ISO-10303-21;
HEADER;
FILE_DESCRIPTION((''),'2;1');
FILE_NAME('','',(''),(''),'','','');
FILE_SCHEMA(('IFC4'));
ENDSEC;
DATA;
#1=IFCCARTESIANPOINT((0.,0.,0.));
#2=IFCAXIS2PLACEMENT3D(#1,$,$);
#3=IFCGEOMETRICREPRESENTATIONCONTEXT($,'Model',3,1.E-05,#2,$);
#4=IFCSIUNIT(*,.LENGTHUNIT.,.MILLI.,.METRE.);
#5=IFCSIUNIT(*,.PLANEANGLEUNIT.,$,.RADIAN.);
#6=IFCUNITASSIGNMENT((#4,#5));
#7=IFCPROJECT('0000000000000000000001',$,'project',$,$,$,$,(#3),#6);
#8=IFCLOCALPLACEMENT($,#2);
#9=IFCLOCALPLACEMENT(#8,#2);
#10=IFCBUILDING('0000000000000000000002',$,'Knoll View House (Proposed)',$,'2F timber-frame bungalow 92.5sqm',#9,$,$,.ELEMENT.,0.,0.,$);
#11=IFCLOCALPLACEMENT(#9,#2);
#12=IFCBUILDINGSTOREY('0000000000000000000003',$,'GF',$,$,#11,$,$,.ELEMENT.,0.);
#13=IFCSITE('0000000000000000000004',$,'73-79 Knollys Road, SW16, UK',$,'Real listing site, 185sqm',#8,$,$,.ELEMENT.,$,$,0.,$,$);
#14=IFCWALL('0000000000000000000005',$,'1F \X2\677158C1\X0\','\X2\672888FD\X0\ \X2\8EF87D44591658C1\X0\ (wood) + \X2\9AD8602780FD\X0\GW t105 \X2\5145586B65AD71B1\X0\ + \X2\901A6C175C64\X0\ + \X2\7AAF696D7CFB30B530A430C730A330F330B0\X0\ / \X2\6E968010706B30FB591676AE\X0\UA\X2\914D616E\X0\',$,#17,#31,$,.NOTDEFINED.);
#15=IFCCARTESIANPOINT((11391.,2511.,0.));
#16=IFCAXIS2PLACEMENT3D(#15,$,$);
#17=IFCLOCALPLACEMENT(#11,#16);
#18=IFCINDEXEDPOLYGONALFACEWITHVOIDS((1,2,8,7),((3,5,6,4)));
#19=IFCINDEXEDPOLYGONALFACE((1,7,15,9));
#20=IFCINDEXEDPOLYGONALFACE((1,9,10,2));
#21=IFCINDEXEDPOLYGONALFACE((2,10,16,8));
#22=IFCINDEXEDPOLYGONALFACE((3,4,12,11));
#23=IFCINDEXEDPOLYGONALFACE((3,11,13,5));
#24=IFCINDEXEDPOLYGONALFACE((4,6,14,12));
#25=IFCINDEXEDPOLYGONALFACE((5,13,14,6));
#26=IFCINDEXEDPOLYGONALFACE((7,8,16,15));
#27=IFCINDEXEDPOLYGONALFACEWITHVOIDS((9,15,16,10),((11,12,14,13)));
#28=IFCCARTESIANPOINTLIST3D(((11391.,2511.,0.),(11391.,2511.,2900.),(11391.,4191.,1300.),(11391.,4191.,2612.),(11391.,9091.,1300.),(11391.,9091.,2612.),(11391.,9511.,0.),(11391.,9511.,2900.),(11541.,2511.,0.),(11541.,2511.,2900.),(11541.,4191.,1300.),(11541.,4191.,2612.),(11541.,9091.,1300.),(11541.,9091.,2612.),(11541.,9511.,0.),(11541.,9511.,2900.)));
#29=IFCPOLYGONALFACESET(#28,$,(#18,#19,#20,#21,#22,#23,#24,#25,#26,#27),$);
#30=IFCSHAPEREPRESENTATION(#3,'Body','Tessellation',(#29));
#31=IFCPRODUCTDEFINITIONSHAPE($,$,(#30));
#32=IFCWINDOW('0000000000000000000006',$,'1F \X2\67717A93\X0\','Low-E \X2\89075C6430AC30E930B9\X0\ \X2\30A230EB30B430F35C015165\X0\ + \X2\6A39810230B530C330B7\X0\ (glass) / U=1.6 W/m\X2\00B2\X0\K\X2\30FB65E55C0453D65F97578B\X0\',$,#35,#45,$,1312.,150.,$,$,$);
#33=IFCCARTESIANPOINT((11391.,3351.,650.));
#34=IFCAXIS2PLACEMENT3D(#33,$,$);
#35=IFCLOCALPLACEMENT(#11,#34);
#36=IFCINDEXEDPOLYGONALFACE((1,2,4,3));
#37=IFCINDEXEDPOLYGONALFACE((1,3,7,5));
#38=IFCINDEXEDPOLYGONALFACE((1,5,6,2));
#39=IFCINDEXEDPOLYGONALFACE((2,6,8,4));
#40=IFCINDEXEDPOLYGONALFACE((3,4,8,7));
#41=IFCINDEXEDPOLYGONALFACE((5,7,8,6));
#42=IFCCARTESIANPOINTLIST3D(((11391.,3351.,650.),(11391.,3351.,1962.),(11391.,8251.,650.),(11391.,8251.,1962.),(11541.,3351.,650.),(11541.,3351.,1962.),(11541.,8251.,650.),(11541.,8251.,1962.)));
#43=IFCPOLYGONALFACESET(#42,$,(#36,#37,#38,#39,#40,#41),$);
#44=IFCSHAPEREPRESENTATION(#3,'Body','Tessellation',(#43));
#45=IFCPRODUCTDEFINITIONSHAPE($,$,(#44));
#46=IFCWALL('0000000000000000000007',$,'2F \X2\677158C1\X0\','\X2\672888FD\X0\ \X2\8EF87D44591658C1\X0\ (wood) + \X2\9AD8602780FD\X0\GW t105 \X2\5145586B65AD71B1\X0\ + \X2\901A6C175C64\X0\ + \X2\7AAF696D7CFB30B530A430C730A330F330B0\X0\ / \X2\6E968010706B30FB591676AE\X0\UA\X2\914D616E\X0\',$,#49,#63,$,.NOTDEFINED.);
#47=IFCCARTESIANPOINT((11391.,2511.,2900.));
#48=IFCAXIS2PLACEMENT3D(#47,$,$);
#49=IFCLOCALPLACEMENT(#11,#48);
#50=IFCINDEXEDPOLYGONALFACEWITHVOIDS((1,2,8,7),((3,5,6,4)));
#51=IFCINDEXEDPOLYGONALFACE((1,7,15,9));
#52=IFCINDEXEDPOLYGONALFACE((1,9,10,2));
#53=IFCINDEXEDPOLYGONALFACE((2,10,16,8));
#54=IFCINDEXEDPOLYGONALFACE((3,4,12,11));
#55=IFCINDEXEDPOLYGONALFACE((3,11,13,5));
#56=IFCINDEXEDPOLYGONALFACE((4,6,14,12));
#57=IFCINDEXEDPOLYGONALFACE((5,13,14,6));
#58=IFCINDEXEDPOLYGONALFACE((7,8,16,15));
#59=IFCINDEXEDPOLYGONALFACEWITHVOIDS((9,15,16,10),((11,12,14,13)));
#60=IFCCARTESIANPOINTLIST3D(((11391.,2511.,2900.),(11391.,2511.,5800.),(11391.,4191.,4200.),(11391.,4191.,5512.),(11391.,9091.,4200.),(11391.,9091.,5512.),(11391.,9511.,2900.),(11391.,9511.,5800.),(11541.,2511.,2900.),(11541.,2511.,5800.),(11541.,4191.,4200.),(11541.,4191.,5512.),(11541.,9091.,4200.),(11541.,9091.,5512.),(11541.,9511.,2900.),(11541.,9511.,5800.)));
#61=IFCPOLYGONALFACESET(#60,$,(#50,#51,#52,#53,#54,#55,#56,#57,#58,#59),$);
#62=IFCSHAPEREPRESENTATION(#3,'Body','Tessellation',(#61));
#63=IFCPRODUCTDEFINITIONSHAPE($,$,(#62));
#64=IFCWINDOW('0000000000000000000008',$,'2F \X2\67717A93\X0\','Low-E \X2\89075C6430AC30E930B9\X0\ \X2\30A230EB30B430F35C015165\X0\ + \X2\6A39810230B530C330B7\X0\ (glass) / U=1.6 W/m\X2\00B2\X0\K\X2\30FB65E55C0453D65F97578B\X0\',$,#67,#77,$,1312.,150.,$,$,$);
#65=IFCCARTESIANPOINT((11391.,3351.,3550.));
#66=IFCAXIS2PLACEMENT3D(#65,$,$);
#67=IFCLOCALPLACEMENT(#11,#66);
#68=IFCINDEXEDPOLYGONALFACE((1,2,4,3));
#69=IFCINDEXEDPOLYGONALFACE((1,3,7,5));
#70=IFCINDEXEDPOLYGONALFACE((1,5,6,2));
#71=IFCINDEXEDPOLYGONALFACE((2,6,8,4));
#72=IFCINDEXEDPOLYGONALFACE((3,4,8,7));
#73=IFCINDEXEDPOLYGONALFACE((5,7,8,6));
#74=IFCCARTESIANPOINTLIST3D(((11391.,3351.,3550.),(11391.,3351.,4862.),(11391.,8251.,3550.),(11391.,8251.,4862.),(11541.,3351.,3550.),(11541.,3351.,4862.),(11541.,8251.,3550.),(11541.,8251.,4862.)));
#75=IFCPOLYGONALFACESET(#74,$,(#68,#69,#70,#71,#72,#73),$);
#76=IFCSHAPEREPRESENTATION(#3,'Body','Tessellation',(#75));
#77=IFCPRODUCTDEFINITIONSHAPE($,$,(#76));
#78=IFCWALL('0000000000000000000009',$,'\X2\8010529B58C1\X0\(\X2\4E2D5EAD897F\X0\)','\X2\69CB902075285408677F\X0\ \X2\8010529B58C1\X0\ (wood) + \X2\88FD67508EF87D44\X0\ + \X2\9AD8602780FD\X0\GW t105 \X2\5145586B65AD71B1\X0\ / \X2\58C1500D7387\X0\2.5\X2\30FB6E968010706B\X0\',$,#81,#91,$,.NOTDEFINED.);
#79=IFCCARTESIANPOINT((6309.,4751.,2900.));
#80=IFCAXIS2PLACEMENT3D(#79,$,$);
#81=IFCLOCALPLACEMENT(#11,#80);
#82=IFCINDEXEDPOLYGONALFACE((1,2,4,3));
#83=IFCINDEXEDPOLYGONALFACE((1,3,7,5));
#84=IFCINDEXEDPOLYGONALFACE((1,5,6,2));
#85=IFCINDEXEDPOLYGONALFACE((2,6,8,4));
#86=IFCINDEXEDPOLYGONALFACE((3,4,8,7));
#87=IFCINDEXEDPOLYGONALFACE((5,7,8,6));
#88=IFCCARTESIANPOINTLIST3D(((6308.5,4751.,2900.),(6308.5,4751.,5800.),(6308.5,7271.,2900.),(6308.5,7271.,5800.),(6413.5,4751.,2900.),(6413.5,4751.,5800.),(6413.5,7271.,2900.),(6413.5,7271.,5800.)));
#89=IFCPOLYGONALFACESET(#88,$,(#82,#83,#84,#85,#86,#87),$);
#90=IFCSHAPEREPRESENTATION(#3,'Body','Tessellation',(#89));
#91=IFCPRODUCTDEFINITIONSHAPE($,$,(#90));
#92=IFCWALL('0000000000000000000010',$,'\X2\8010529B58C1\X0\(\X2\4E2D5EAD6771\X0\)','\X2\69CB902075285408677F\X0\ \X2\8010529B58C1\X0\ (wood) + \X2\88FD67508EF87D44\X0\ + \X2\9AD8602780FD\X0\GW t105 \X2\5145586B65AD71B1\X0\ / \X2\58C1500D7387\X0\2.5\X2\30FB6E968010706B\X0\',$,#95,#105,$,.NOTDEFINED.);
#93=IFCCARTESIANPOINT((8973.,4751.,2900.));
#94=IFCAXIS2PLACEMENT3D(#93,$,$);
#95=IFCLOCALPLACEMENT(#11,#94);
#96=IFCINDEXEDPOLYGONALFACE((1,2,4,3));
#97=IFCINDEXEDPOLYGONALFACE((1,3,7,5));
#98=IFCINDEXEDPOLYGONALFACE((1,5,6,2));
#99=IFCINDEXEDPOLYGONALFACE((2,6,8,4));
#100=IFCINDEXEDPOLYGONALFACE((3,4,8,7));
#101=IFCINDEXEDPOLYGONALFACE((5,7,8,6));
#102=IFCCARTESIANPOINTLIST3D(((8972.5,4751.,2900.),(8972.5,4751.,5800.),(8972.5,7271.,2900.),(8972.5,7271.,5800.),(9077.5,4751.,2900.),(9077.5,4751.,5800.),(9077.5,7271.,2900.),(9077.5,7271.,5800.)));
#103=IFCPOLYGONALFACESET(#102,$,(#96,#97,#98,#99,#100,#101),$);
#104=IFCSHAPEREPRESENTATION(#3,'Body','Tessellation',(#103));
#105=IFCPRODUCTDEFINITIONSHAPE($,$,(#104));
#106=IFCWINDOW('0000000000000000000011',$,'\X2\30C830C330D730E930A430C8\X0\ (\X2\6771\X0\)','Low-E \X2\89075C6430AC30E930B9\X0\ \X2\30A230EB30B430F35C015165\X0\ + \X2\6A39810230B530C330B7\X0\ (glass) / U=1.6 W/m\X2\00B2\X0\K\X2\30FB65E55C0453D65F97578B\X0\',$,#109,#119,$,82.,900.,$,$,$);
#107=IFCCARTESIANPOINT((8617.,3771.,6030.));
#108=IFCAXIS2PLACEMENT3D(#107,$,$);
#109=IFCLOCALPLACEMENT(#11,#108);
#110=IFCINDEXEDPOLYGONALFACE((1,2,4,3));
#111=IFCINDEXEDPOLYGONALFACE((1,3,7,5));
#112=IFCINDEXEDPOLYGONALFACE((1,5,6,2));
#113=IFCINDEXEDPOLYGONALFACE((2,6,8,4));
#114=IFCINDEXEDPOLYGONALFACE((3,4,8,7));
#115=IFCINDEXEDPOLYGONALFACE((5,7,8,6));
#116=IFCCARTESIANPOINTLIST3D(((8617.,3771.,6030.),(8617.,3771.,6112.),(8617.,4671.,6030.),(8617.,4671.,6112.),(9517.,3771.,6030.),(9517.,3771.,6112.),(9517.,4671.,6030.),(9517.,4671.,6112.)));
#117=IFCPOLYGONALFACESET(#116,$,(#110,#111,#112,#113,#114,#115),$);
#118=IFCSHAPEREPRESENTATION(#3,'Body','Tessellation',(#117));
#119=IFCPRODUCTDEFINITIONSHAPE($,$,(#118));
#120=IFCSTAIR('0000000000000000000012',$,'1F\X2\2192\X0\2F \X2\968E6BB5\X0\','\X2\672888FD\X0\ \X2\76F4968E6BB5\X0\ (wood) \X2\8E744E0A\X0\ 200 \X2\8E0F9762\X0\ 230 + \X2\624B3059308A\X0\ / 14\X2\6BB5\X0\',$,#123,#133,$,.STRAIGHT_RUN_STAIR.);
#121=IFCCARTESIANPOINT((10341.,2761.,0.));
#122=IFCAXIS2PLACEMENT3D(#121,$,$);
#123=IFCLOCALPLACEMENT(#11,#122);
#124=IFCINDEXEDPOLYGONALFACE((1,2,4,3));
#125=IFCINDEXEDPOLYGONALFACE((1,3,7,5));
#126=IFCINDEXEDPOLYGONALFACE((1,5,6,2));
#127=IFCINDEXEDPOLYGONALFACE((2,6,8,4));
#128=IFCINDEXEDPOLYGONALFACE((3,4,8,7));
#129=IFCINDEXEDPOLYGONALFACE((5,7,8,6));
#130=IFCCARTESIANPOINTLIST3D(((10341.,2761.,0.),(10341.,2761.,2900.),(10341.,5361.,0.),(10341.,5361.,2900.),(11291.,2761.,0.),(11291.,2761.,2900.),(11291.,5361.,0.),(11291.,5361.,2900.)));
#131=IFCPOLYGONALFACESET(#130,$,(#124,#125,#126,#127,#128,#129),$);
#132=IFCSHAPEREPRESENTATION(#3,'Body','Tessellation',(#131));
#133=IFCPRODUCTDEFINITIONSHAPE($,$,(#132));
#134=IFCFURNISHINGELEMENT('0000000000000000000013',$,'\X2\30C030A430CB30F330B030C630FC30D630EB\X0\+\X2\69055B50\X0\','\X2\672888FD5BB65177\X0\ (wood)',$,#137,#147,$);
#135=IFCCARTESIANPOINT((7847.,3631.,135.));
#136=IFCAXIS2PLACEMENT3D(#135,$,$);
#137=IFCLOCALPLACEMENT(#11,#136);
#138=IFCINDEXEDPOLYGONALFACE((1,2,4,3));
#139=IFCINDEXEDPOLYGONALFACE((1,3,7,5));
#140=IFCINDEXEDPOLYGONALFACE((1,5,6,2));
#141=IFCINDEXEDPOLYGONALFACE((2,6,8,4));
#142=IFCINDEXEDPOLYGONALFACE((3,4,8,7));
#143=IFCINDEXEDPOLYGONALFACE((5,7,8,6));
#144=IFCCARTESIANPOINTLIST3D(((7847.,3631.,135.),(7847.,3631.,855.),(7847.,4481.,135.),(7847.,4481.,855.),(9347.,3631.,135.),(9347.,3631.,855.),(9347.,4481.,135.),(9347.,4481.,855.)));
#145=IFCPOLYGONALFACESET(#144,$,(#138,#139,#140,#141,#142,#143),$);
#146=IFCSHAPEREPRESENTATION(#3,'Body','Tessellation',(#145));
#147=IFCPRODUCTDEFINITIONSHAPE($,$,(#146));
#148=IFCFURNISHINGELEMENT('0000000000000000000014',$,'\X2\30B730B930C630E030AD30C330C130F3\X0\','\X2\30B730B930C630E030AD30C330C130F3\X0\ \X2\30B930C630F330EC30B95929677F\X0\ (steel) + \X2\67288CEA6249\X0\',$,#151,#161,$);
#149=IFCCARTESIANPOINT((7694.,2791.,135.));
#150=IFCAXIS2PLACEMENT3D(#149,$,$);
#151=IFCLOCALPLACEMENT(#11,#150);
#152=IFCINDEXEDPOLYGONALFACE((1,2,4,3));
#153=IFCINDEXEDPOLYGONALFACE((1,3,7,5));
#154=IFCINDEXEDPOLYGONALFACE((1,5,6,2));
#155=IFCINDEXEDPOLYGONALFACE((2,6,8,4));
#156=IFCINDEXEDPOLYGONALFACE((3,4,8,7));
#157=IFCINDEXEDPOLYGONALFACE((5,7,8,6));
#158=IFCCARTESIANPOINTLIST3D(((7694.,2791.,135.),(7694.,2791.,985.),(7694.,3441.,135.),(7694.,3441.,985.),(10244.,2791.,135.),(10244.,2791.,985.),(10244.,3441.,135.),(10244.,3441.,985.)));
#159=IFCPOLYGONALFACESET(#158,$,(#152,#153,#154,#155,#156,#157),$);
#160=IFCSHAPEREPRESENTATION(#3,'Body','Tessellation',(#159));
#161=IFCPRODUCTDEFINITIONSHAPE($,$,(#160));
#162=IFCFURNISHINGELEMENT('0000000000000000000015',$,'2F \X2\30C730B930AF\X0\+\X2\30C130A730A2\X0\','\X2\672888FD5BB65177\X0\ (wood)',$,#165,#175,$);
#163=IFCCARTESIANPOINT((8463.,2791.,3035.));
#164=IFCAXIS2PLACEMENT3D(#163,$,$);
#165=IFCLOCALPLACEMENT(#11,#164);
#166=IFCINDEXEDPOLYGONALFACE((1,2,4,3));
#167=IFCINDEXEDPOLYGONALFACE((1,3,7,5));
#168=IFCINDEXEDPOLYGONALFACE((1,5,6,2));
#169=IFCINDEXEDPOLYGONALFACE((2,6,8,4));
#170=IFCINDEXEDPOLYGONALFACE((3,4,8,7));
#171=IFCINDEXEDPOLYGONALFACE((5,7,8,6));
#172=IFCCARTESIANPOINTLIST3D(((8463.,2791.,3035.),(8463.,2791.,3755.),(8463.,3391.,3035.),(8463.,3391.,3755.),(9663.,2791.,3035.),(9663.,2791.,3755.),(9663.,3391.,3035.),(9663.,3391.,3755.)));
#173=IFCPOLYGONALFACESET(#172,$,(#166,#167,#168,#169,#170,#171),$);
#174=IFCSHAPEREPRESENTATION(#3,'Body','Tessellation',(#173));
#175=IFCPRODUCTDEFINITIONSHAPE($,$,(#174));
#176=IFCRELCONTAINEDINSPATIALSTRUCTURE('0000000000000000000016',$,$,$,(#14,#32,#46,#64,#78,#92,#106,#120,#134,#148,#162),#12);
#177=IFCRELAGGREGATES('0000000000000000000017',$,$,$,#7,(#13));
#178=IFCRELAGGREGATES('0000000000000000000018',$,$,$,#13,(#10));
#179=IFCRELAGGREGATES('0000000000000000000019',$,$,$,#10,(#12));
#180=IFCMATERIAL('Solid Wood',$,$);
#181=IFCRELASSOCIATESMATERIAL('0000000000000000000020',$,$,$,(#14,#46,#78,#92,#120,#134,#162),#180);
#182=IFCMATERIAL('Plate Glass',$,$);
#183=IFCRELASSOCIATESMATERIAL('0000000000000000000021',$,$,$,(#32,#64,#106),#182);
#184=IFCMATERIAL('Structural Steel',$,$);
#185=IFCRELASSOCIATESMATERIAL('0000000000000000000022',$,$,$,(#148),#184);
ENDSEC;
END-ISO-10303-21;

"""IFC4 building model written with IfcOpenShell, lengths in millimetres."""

from ifc_helpers import new_model, si_unit, frame, frame_2d, origin, place, context, project, spatial, rectangle, extrude, material, element, fill, save


model = new_model("IFC4")

# Units and contexts
model_context = context("Model", 3, precision=1e-05, world=origin())
ifc_project = project(units=[si_unit("LENGTHUNIT", "METRE", prefix="MILLI"), si_unit("PLANEANGLEUNIT", "RADIAN")], contexts=[model_context])

# Site, building, storey
site_placement = place(None, origin())
site = spatial("IfcSite", under=ifc_project, at=site_placement, Name="73-79 Knollys Road, SW16, UK", ObjectType="Real listing site, 185sqm", CompositionType="ELEMENT", RefElevation=0.0)
building_placement = place(site_placement, origin())
building = spatial("IfcBuilding", under=site, at=building_placement, Name="Knoll View House (Proposed)", ObjectType="2F timber-frame bungalow 92.5sqm", CompositionType="ELEMENT", ElevationOfRefHeight=0.0, ElevationOfTerrain=0.0)
storey_placement = place(building_placement, origin())
storey = spatial("IfcBuildingStorey", under=building, at=storey_placement, Name="GF", CompositionType="ELEMENT", Elevation=0.0)

# Shared definitions
ifc_material_1 = material(Name="Solid Wood")

# Wall, opening, window
wall_1_placement = place(storey_placement, frame((11391.0, 2511.0, 0.0)))
wall_1 = element("IfcWall", 1, at=wall_1_placement, inside=storey, material=ifc_material_1, Name="1F 東壁", Description="木製 軸組外壁 (wood) + 高性能GW t105 充填断熱 + 通気層 + 窯業系サイディング / 準耐火・外皮UA配慮", PredefinedType="NOTDEFINED", context=model_context, shape_type="SweptSolid", body=[
    extrude(rectangle(XDim=150.0, YDim=7000.0, at=frame_2d((75.0, 3500.0))), frame((11391.0, 2511.0, 0.0)), (0.0, 0.0, 1.0), 2900.0),
])
opening_1_placement = place(storey_placement, frame((11391.0, 3351.0, 650.0)))
opening_1 = element("IfcOpeningElement", 2, at=opening_1_placement, cuts=wall_1, PredefinedType="NOTDEFINED", context=model_context, shape_type="SweptSolid", body=[
    extrude(rectangle(XDim=150.0, YDim=4900.0, at=frame_2d((75.0, 2450.0))), frame((11391.0, 3351.0, 650.0)), (0.0, 0.0, 1.0), 1312.0),
])
ifc_material_2 = material(Name="Plate Glass")
window_1_placement = place(storey_placement, frame((11391.0, 3351.0, 650.0)))
window_1 = element("IfcWindow", 3, at=window_1_placement, inside=storey, material=ifc_material_2, Name="1F 東窓", Description="Low-E 複層ガラス アルゴン封入 + 樹脂サッシ (glass) / U=1.6 W/m²K・日射取得型", OverallHeight=1312.0, OverallWidth=150.0, context=model_context, shape_type="SweptSolid", body=[
    extrude(rectangle(XDim=150.0, YDim=4900.0, at=frame_2d((75.0, 2450.0))), frame((11391.0, 3351.0, 650.0)), (0.0, 0.0, 1.0), 1312.0),
])
fill(opening_1, window_1)

# Wall, opening, window
wall_2_placement = place(storey_placement, frame((11391.0, 2511.0, 2900.0)))
wall_2 = element("IfcWall", 4, at=wall_2_placement, inside=storey, material=ifc_material_1, Name="2F 東壁", Description="木製 軸組外壁 (wood) + 高性能GW t105 充填断熱 + 通気層 + 窯業系サイディング / 準耐火・外皮UA配慮", PredefinedType="NOTDEFINED", context=model_context, shape_type="SweptSolid", body=[
    extrude(rectangle(XDim=150.0, YDim=7000.0, at=frame_2d((75.0, 3500.0))), frame((11391.0, 2511.0, 2900.0)), (0.0, 0.0, 1.0), 2900.0),
])
opening_2_placement = place(storey_placement, frame((11391.0, 3351.0, 3550.0)))
opening_2 = element("IfcOpeningElement", 5, at=opening_2_placement, cuts=wall_2, PredefinedType="NOTDEFINED", context=model_context, shape_type="SweptSolid", body=[
    extrude(rectangle(XDim=150.0, YDim=4900.0, at=frame_2d((75.0, 2450.0))), frame((11391.0, 3351.0, 3550.0)), (0.0, 0.0, 1.0), 1312.0),
])
window_2_placement = place(storey_placement, frame((11391.0, 3351.0, 3550.0)))
window_2 = element("IfcWindow", 6, at=window_2_placement, inside=storey, material=ifc_material_2, Name="2F 東窓", Description="Low-E 複層ガラス アルゴン封入 + 樹脂サッシ (glass) / U=1.6 W/m²K・日射取得型", OverallHeight=1312.0, OverallWidth=150.0, context=model_context, shape_type="SweptSolid", body=[
    extrude(rectangle(XDim=150.0, YDim=4900.0, at=frame_2d((75.0, 2450.0))), frame((11391.0, 3351.0, 3550.0)), (0.0, 0.0, 1.0), 1312.0),
])
fill(opening_2, window_2)

# Walls
wall_3_placement = place(storey_placement, frame((6309.0, 4751.0, 2900.0)))
element("IfcWall", 7, at=wall_3_placement, inside=storey, material=ifc_material_1, Name="耐力壁(中庭西)", Description="構造用合板 耐力壁 (wood) + 製材軸組 + 高性能GW t105 充填断熱 / 壁倍率2.5・準耐火", PredefinedType="NOTDEFINED", context=model_context, shape_type="SweptSolid", body=[
    extrude(rectangle(XDim=105.0, YDim=2520.0, at=frame_2d((52.0, 1260.0))), frame((6309.0, 4751.0, 2900.0)), (0.0, 0.0, 1.0), 2900.0),
])
wall_4_placement = place(storey_placement, frame((8973.0, 4751.0, 2900.0)))
element("IfcWall", 8, at=wall_4_placement, inside=storey, material=ifc_material_1, Name="耐力壁(中庭東)", Description="構造用合板 耐力壁 (wood) + 製材軸組 + 高性能GW t105 充填断熱 / 壁倍率2.5・準耐火", PredefinedType="NOTDEFINED", context=model_context, shape_type="SweptSolid", body=[
    extrude(rectangle(XDim=105.0, YDim=2520.0, at=frame_2d((52.0, 1260.0))), frame((8973.0, 4751.0, 2900.0)), (0.0, 0.0, 1.0), 2900.0),
])

# Window
window_3_placement = place(storey_placement, frame((8617.0, 3771.0, 6030.0)))
element("IfcWindow", 9, at=window_3_placement, inside=storey, material=ifc_material_2, Name="トップライト (東)", Description="Low-E 複層ガラス アルゴン封入 + 樹脂サッシ (glass) / U=1.6 W/m²K・日射取得型", OverallHeight=82.0, OverallWidth=900.0, context=model_context, shape_type="SweptSolid", body=[
    extrude(rectangle(XDim=900.0, YDim=900.0, at=frame_2d((450.0, 450.0))), frame((8617.0, 3771.0, 6030.0)), (0.0, 0.0, 1.0), 82.0),
])

# Stair
stair_placement = place(storey_placement, frame((10341.0, 2761.0, 0.0)))
element("IfcStair", 10, at=stair_placement, inside=storey, material=ifc_material_1, Name="1F→2F 階段", Description="木製 直階段 (wood) 蹴上 200 踏面 230 + 手すり / 14段", PredefinedType="STRAIGHT_RUN_STAIR", context=model_context, shape_type="SweptSolid", body=[
    extrude(rectangle(XDim=950.0, YDim=2600.0, at=frame_2d((475.0, 1300.0))), frame((10341.0, 2761.0, 0.0)), (0.0, 0.0, 1.0), 2900.0),
])

# Furnishing elements
furnishing_1_placement = place(storey_placement, frame((7847.0, 3631.0, 135.0)))
element("IfcFurnishingElement", 11, at=furnishing_1_placement, inside=storey, material=ifc_material_1, Name="ダイニングテーブル+椅子", Description="木製家具 (wood)", context=model_context, shape_type="SweptSolid", body=[
    extrude(rectangle(XDim=1500.0, YDim=850.0, at=frame_2d((750.0, 425.0))), frame((7847.0, 3631.0, 135.0)), (0.0, 0.0, 1.0), 720.0),
])
ifc_material_3 = material(Name="Structural Steel")
furnishing_2_placement = place(storey_placement, frame((7694.0, 2791.0, 135.0)))
element("IfcFurnishingElement", 12, at=furnishing_2_placement, inside=storey, material=ifc_material_3, Name="システムキッチン", Description="システムキッチン ステンレス天板 (steel) + 木質扉", context=model_context, shape_type="SweptSolid", body=[
    extrude(rectangle(XDim=2550.0, YDim=650.0, at=frame_2d((1275.0, 325.0))), frame((7694.0, 2791.0, 135.0)), (0.0, 0.0, 1.0), 850.0),
])
furnishing_3_placement = place(storey_placement, frame((8463.0, 2791.0, 3035.0)))
element("IfcFurnishingElement", 13, at=furnishing_3_placement, inside=storey, material=ifc_material_1, Name="2F デスク+チェア", Description="木製家具 (wood)", context=model_context, shape_type="SweptSolid", body=[
    extrude(rectangle(XDim=1200.0, YDim=600.0, at=frame_2d((600.0, 300.0))), frame((8463.0, 2791.0, 3035.0)), (0.0, 0.0, 1.0), 720.0),
])

save(model, "model.ifc")
